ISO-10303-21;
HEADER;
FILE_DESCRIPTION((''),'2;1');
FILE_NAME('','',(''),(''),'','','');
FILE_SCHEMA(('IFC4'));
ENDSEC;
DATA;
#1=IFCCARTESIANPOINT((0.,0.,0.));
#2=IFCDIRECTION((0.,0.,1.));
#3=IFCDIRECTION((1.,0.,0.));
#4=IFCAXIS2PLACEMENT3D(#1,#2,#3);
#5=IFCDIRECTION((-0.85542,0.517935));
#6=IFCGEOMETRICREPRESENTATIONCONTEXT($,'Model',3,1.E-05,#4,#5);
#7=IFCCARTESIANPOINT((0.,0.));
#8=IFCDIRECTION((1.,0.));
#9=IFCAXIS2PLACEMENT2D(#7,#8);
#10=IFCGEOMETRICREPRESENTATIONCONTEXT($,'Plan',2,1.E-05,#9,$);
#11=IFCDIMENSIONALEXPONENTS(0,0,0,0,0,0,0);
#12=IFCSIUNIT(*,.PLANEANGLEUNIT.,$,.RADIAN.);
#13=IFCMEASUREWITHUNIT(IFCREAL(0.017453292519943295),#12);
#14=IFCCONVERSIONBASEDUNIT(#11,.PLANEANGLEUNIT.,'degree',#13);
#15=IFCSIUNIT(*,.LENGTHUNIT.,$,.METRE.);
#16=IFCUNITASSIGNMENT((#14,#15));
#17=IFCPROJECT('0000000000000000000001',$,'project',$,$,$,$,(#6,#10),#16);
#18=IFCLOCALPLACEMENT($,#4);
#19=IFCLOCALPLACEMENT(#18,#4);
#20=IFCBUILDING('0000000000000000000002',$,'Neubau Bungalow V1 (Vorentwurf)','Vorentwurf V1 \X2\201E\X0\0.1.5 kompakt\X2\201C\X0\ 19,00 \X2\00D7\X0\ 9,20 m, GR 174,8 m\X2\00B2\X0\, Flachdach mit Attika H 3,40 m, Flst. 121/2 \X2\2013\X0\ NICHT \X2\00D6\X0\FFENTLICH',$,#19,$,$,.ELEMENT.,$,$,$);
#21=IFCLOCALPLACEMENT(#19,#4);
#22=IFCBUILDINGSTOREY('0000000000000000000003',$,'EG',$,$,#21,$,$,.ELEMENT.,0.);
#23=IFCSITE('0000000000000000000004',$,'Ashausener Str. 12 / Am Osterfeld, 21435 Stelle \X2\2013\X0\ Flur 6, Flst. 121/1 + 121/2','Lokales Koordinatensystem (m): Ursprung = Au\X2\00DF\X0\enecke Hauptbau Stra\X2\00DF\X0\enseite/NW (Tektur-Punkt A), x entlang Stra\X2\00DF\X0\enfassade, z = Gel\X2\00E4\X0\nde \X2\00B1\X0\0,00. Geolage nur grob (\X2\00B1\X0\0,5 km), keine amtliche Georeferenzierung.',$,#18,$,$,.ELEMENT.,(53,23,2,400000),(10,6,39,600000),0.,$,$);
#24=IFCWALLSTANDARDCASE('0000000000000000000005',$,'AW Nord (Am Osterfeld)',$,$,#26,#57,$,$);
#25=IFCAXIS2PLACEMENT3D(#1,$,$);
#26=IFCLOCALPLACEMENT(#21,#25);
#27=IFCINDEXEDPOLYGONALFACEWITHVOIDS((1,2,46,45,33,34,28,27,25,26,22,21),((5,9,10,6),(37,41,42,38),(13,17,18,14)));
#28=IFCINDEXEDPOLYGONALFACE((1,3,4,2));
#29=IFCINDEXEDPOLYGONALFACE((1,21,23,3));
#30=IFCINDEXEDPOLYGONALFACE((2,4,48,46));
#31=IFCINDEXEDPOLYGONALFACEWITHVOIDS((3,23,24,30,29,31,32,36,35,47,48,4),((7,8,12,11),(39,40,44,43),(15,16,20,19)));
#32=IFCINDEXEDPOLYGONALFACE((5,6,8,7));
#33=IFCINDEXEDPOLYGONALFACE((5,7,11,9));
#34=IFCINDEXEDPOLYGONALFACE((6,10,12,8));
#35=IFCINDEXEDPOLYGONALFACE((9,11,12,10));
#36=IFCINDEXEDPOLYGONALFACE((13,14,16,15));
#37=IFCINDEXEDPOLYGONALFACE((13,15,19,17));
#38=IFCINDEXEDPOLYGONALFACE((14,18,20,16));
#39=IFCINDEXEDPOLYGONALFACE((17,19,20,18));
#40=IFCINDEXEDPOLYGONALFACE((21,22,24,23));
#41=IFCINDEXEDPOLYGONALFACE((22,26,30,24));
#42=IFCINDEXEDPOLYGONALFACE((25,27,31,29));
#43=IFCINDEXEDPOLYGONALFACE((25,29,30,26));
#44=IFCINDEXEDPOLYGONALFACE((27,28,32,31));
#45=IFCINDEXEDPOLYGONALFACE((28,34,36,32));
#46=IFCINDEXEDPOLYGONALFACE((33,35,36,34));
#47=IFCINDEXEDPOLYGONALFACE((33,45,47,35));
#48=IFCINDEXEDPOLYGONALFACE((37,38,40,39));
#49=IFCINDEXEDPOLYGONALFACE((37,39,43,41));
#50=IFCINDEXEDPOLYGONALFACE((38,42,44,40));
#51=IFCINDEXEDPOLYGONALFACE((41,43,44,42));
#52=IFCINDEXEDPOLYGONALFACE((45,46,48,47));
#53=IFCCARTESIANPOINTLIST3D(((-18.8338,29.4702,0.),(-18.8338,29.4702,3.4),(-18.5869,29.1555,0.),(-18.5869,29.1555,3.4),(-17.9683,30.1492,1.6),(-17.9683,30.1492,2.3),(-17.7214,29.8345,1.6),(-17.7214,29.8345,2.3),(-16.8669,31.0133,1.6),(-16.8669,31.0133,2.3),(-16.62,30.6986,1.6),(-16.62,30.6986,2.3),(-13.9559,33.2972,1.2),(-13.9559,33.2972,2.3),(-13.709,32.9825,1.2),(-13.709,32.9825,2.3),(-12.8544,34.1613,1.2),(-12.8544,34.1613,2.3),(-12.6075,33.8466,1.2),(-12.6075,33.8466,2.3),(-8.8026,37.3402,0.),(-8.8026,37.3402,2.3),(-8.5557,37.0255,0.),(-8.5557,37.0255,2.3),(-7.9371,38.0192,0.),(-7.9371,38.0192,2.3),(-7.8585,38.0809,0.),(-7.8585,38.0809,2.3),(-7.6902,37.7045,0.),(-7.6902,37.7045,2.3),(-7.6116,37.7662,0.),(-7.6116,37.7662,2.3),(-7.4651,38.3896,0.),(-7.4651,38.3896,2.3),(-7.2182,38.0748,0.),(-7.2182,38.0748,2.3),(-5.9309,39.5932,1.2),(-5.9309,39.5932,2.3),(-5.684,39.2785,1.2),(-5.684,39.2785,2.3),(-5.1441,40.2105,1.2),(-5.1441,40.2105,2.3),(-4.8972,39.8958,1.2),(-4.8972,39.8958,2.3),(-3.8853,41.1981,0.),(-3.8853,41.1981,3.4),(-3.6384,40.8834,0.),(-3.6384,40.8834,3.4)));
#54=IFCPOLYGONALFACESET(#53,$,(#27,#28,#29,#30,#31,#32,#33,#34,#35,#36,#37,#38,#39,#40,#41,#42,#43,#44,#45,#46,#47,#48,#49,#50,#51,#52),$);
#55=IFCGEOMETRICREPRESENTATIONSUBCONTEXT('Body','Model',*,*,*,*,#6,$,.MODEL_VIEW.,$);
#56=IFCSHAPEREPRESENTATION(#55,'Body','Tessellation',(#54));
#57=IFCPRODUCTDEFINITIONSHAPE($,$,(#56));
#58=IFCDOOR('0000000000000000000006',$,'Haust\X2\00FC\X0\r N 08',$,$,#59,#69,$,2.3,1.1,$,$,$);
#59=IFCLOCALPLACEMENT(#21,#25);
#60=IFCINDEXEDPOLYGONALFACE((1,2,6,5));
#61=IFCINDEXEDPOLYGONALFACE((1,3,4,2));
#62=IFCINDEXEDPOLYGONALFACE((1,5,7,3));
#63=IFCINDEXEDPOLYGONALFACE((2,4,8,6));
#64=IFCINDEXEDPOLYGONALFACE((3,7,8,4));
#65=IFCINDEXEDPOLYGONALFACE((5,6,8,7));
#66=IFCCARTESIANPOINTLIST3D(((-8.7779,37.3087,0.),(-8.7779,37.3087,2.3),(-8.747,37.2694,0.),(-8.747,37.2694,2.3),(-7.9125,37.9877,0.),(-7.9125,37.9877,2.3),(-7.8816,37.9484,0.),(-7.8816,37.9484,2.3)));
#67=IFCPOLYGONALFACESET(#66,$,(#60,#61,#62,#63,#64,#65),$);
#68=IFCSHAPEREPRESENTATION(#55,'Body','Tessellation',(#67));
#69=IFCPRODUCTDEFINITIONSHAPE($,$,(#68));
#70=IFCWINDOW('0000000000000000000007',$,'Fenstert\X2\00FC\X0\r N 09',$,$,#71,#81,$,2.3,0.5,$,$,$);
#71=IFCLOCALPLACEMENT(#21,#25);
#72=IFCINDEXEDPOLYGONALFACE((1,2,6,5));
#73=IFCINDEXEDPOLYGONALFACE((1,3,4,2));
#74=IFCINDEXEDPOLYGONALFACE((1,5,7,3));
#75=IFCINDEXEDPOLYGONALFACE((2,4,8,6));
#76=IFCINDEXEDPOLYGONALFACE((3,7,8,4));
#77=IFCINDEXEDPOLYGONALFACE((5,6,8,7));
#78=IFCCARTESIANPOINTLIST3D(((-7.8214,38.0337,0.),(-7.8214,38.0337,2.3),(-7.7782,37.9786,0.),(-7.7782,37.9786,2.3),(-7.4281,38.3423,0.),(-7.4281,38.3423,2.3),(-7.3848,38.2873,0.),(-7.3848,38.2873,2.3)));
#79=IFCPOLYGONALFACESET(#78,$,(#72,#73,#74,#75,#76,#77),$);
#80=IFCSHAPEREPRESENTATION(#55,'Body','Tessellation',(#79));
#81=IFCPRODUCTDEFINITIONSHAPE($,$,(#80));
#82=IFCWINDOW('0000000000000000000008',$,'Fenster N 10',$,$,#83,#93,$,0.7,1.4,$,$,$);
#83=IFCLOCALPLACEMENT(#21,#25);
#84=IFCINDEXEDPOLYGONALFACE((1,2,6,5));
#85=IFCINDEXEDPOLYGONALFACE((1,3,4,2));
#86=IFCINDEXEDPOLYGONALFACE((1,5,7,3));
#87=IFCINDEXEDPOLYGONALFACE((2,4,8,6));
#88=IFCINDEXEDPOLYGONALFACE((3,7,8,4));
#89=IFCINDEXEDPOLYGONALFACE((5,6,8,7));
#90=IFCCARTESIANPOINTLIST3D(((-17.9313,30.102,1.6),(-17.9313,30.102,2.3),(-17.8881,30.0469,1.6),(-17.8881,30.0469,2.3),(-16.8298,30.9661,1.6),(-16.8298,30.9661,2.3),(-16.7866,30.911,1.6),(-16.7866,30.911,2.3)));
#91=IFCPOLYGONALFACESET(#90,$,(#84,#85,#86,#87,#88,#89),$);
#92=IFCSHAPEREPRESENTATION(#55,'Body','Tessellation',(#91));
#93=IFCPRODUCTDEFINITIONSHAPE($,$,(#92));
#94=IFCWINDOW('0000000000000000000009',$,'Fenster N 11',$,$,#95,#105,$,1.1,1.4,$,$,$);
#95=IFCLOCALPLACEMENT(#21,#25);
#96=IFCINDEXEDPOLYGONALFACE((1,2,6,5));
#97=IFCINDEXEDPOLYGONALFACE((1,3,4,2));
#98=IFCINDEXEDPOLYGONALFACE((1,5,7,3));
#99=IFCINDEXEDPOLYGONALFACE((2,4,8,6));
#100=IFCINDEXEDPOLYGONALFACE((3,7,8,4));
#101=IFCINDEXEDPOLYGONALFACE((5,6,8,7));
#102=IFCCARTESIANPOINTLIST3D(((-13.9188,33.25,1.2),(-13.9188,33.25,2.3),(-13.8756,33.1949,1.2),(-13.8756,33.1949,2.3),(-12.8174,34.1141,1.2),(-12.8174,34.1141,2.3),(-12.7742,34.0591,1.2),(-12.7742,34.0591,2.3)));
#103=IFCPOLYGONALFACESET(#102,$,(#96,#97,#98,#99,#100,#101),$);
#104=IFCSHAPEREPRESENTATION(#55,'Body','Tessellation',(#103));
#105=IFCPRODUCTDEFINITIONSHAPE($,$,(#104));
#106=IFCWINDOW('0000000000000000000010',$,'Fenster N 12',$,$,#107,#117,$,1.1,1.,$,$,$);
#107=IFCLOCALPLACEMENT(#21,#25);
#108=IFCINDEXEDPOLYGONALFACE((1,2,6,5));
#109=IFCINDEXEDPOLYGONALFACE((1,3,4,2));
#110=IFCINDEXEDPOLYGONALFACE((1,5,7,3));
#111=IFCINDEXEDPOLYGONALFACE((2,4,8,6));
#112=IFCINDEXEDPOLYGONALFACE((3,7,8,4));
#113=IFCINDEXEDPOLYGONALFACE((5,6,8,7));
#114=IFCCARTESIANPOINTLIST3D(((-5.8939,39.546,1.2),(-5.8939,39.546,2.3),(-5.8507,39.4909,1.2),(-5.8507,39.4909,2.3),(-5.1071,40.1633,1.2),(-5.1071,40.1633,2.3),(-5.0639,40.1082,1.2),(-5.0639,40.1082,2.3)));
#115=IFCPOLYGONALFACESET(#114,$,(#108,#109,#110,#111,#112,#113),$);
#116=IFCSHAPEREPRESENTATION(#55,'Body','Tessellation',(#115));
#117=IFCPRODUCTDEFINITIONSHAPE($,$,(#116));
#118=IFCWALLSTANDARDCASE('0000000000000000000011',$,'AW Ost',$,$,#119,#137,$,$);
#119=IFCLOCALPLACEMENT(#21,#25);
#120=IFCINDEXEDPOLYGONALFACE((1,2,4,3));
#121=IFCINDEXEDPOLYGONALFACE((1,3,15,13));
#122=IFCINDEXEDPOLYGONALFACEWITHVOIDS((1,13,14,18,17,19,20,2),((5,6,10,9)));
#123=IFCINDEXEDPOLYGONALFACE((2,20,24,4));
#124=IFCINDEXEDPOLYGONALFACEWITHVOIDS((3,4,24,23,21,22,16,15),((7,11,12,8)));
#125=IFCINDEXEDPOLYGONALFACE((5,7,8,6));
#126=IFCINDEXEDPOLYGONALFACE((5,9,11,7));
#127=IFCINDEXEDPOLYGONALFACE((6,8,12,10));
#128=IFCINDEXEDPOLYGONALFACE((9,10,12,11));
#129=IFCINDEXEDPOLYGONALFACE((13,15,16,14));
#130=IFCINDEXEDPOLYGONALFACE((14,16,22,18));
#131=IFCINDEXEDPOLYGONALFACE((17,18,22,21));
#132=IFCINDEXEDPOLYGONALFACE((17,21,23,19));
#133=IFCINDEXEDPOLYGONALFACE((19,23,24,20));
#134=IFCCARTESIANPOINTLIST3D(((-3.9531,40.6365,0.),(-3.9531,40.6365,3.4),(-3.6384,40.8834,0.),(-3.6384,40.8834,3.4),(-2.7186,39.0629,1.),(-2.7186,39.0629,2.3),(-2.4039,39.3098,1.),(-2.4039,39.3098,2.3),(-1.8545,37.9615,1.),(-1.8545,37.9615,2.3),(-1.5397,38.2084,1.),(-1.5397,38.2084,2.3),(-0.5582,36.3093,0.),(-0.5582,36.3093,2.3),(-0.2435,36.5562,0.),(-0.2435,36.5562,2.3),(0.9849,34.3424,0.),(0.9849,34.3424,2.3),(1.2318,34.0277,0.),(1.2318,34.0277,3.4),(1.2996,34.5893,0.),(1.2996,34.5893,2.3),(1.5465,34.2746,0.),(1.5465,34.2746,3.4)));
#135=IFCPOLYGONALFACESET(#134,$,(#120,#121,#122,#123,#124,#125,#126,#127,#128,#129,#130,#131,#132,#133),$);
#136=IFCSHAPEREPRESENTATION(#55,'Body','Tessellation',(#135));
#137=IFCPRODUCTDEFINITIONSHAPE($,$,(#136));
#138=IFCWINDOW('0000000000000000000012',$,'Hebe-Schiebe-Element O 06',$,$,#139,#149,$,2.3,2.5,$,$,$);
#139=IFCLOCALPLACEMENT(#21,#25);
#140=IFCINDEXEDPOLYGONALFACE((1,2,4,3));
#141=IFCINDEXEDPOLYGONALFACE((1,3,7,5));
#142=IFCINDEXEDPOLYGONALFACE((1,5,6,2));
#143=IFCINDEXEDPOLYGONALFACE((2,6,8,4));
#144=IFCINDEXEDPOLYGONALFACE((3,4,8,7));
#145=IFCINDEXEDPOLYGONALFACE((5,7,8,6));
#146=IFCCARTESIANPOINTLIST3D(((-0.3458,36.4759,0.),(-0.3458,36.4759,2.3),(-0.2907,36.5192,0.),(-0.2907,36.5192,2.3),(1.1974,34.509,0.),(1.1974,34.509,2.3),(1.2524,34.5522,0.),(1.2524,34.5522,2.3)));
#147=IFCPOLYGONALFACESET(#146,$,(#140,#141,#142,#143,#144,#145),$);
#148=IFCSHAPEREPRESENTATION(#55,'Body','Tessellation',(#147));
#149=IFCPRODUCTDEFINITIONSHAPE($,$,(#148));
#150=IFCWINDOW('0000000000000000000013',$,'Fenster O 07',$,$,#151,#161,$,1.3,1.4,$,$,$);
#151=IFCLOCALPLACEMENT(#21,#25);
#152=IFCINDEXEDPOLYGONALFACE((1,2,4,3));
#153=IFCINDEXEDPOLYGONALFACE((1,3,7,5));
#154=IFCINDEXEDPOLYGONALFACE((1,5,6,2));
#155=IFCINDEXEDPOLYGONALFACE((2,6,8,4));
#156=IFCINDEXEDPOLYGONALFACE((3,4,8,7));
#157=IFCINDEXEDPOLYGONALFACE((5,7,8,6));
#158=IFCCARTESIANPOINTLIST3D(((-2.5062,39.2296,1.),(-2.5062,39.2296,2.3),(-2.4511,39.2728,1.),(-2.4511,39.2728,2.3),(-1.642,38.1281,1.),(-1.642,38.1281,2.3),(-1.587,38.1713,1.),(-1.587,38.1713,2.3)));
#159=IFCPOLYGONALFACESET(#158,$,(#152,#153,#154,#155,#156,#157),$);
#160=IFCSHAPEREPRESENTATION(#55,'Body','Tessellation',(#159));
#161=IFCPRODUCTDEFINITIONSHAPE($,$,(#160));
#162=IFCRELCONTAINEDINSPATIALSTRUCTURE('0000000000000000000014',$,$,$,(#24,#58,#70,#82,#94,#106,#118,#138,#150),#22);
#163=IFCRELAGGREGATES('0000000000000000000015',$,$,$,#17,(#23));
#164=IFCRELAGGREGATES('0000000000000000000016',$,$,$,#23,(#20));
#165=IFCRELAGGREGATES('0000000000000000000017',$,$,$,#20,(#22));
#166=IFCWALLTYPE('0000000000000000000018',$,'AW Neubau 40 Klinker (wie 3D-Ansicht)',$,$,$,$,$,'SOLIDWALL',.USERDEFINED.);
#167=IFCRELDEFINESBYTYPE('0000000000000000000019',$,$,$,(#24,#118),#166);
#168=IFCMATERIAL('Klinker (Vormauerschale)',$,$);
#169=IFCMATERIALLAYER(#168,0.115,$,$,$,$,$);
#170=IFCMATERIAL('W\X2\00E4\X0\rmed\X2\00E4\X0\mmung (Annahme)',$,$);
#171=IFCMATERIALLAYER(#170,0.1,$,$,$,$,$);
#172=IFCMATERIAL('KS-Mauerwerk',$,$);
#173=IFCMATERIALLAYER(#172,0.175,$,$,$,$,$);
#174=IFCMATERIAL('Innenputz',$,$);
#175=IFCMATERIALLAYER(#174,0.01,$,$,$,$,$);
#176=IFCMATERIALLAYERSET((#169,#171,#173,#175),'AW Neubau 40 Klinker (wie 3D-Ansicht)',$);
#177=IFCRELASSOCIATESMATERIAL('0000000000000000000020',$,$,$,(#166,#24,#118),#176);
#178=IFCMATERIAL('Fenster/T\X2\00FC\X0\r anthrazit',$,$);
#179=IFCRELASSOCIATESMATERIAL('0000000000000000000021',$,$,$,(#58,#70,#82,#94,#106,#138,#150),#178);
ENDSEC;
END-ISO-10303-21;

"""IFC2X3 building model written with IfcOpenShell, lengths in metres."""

from ifc_helpers import new_model, entity, si_unit, converted_unit, direction, frame, origin_with_axes, origin_2d_with_axis, place, context, subcontext, project, spatial, polyline, outline, extrude, material, layer, layer_set, layer_usage, type_object, element, fill, save


model = new_model("IFC2X3")

# Units and contexts
model_context = context("Model", 3, precision=1e-05, world=origin_with_axes(), true_north=direction((-0.85542, 0.517935)))
plan_context = context("Plan", 2, precision=1e-05, world=origin_2d_with_axis())
body_context = subcontext(model_context, "Body", "Model", "MODEL_VIEW")
ifc_project = project(units=[converted_unit("PLANEANGLEUNIT", "degree", entity("IfcReal", 0.017453292519943295), si_unit("PLANEANGLEUNIT", "RADIAN"), dimensions=[0, 0, 0, 0, 0, 0, 0]), si_unit("LENGTHUNIT", "METRE")], contexts=[model_context, plan_context])

# Site, building, storey
site_placement = place(None, origin_with_axes())
site = spatial("IfcSite", under=ifc_project, at=site_placement, Name="Ashausener Str. 12 / Am Osterfeld, 21435 Stelle – Flur 6, Flst. 121/1 + 121/2", Description="Lokales Koordinatensystem (m): Ursprung = Außenecke Hauptbau Straßenseite/NW (Tektur-Punkt A), x entlang Straßenfassade, z = Gelände ±0,00. Geolage nur grob (±0,5 km), keine amtliche Georeferenzierung.", CompositionType="ELEMENT", RefLatitude=(53, 23, 2, 400000), RefLongitude=(10, 6, 39, 600000), RefElevation=0.0)
building_placement = place(site_placement, origin_with_axes())
building = spatial("IfcBuilding", under=site, at=building_placement, Name="Neubau Bungalow V1 (Vorentwurf)", Description="Vorentwurf V1 „0.1.5 kompakt“ 19,00 × 9,20 m, GR 174,8 m², Flachdach mit Attika H 3,40 m, Flst. 121/2 – NICHT ÖFFENTLICH", CompositionType="ELEMENT")
storey_placement = place(building_placement, origin_with_axes())
storey = spatial("IfcBuildingStorey", under=building, at=storey_placement, Name="EG", CompositionType="ELEMENT", Elevation=0.0)

# Wall, openings, door, windows
ifc_material_1 = material(Name="Klinker (Vormauerschale)")
ifc_layer_1 = layer(ifc_material_1, 0.115)
ifc_material_2 = material(Name="Wärmedämmung (Annahme)")
ifc_layer_2 = layer(ifc_material_2, 0.1)
ifc_material_3 = material(Name="KS-Mauerwerk")
ifc_layer_3 = layer(ifc_material_3, 0.175)
ifc_material_4 = material(Name="Innenputz")
ifc_layer_4 = layer(ifc_material_4, 0.01)
ifc_layer_set_1 = layer_set([ifc_layer_1, ifc_layer_2, ifc_layer_3, ifc_layer_4], Name="AW Neubau 40 Klinker (wie 3D-Ansicht)")
ifc_layer_usage_1 = layer_usage(ifc_layer_set_1, "AXIS2", "POSITIVE", 0.0)
wall_type_1 = type_object("IfcWallType", Name="AW Neubau 40 Klinker (wie 3D-Ansicht)", ElementType="SOLIDWALL", PredefinedType="USERDEFINED", material=ifc_layer_set_1)
wall_1_placement = place(storey_placement, frame((-3.8853, 41.1981, 0.0), z_axis=(0.0, 0.0, 1.0), x_axis=(-0.786761, -0.617258, 0.0)))
wall_1 = element("IfcWallStandardCase", 1, at=wall_1_placement, inside=storey, type_object=wall_type_1, material=ifc_layer_usage_1, Name="AW Nord (Am Osterfeld)", context=body_context, shape_type="SweptSolid", body=[
    extrude(outline(polyline([(0.0, 0.0), (0.0, 0.4), (19.0, 0.4), (19.0, 0.0), (0.0, 0.0)])), origin_with_axes(), (0.0, 0.0, 1.0), 3.4),
])
opening_1_placement = place(wall_1_placement, frame((5.15, -0.1, 0.0), z_axis=(0.0, 0.0, 1.0), x_axis=(1.0, 0.0, 0.0)))
opening_1 = element("IfcOpeningElement", 2, at=opening_1_placement, cuts=wall_1, context=body_context, shape_type="SweptSolid", body=[
    extrude(outline(polyline([(0.0, 0.0), (0.0, 0.6), (1.1, 0.6), (1.1, 0.0), (0.0, 0.0)])), origin_with_axes(), (0.0, 0.0, 1.0), 2.3),
])
opening_2_placement = place(wall_1_placement, frame((4.55, -0.1, 0.0), z_axis=(0.0, 0.0, 1.0), x_axis=(1.0, 0.0, 0.0)))
opening_2 = element("IfcOpeningElement", 3, at=opening_2_placement, cuts=wall_1, context=body_context, shape_type="SweptSolid", body=[
    extrude(outline(polyline([(0.0, 0.0), (0.0, 0.6), (0.5, 0.6), (0.5, 0.0), (0.0, 0.0)])), origin_with_axes(), (0.0, 0.0, 1.0), 2.3),
])
opening_3_placement = place(wall_1_placement, frame((16.5, -0.1, 1.6), z_axis=(0.0, 0.0, 1.0), x_axis=(1.0, 0.0, 0.0)))
opening_3 = element("IfcOpeningElement", 4, at=opening_3_placement, cuts=wall_1, context=body_context, shape_type="SweptSolid", body=[
    extrude(outline(polyline([(0.0, 0.0), (0.0, 0.6), (1.4, 0.6), (1.4, 0.0), (0.0, 0.0)])), origin_with_axes(), (0.0, 0.0, 1.0), 0.7),
])
opening_4_placement = place(wall_1_placement, frame((11.4, -0.1, 1.2), z_axis=(0.0, 0.0, 1.0), x_axis=(1.0, 0.0, 0.0)))
opening_4 = element("IfcOpeningElement", 5, at=opening_4_placement, cuts=wall_1, context=body_context, shape_type="SweptSolid", body=[
    extrude(outline(polyline([(0.0, 0.0), (0.0, 0.6), (1.4, 0.6), (1.4, 0.0), (0.0, 0.0)])), origin_with_axes(), (0.0, 0.0, 1.0), 1.1),
])
opening_5_placement = place(wall_1_placement, frame((1.6, -0.1, 1.2), z_axis=(0.0, 0.0, 1.0), x_axis=(1.0, 0.0, 0.0)))
opening_5 = element("IfcOpeningElement", 6, at=opening_5_placement, cuts=wall_1, context=body_context, shape_type="SweptSolid", body=[
    extrude(outline(polyline([(0.0, 0.0), (0.0, 0.6), (1.0, 0.6), (1.0, 0.0), (0.0, 0.0)])), origin_with_axes(), (0.0, 0.0, 1.0), 1.1),
])
ifc_material_5 = material(Name="Fenster/Tür anthrazit")
door_placement = place(storey_placement, frame((-7.9125, 37.9877, 0.0), z_axis=(0.0, 0.0, 1.0), x_axis=(-0.786761, -0.617258, 0.0)))
door = element("IfcDoor", 7, at=door_placement, inside=storey, material=ifc_material_5, Name="Haustür N 08", OverallHeight=2.3, OverallWidth=1.1, context=body_context, shape_type="SweptSolid", body=[
    extrude(outline(polyline([(0.0, 0.0), (0.0, 0.05), (1.1, 0.05), (1.1, 0.0), (0.0, 0.0)])), origin_with_axes(), (0.0, 0.0, 1.0), 2.3),
])
fill(opening_1, door)
window_1_placement = place(storey_placement, frame((-7.4281, 38.3423, 0.0), z_axis=(0.0, 0.0, 1.0), x_axis=(-0.786761, -0.617258, 0.0)))
window_1 = element("IfcWindow", 8, at=window_1_placement, inside=storey, material=ifc_material_5, Name="Fenstertür N 09", OverallHeight=2.3, OverallWidth=0.5, context=body_context, shape_type="SweptSolid", body=[
    extrude(outline(polyline([(0.0, 0.0), (0.0, 0.07), (0.5, 0.07), (0.5, 0.0), (0.0, 0.0)])), origin_with_axes(), (0.0, 0.0, 1.0), 2.3),
])
fill(opening_2, window_1)
window_2_placement = place(storey_placement, frame((-16.8298, 30.9661, 1.6), z_axis=(0.0, 0.0, 1.0), x_axis=(-0.786761, -0.617258, 0.0)))
window_2 = element("IfcWindow", 9, at=window_2_placement, inside=storey, material=ifc_material_5, Name="Fenster N 10", OverallHeight=0.7, OverallWidth=1.4, context=body_context, shape_type="SweptSolid", body=[
    extrude(outline(polyline([(0.0, 0.0), (0.0, 0.07), (1.4, 0.07), (1.4, 0.0), (0.0, 0.0)])), origin_with_axes(), (0.0, 0.0, 1.0), 0.7),
])
fill(opening_3, window_2)
window_3_placement = place(storey_placement, frame((-12.8174, 34.1141, 1.2), z_axis=(0.0, 0.0, 1.0), x_axis=(-0.786761, -0.617258, 0.0)))
window_3 = element("IfcWindow", 10, at=window_3_placement, inside=storey, material=ifc_material_5, Name="Fenster N 11", OverallHeight=1.1, OverallWidth=1.4, context=body_context, shape_type="SweptSolid", body=[
    extrude(outline(polyline([(0.0, 0.0), (0.0, 0.07), (1.4, 0.07), (1.4, 0.0), (0.0, 0.0)])), origin_with_axes(), (0.0, 0.0, 1.0), 1.1),
])
fill(opening_4, window_3)
window_4_placement = place(storey_placement, frame((-5.1071, 40.1633, 1.2), z_axis=(0.0, 0.0, 1.0), x_axis=(-0.786761, -0.617258, 0.0)))
window_4 = element("IfcWindow", 11, at=window_4_placement, inside=storey, material=ifc_material_5, Name="Fenster N 12", OverallHeight=1.1, OverallWidth=1.0, context=body_context, shape_type="SweptSolid", body=[
    extrude(outline(polyline([(0.0, 0.0), (0.0, 0.07), (1.0, 0.07), (1.0, 0.0), (0.0, 0.0)])), origin_with_axes(), (0.0, 0.0, 1.0), 1.1),
])
fill(opening_5, window_4)

# Wall, openings, windows
ifc_layer_usage_2 = layer_usage(ifc_layer_set_1, "AXIS2", "POSITIVE", 0.0)
wall_2_placement = place(storey_placement, frame((1.5465, 34.2746, 0.0), z_axis=(0.0, 0.0, 1.0), x_axis=(-0.617258, 0.786761, 0.0)))
wall_2 = element("IfcWallStandardCase", 12, at=wall_2_placement, inside=storey, type_object=wall_type_1, material=ifc_layer_usage_2, Name="AW Ost", context=body_context, shape_type="SweptSolid", body=[
    extrude(outline(polyline([(0.0, 0.0), (0.0, 0.4), (8.4, 0.4), (8.4, 0.0), (0.0, 0.0)])), origin_with_axes(), (0.0, 0.0, 1.0), 3.4),
])
opening_6_placement = place(wall_2_placement, frame((0.4, -0.1, 0.0), z_axis=(0.0, 0.0, 1.0), x_axis=(1.0, 0.0, 0.0)))
opening_6 = element("IfcOpeningElement", 13, at=opening_6_placement, cuts=wall_2, context=body_context, shape_type="SweptSolid", body=[
    extrude(outline(polyline([(0.0, 0.0), (0.0, 0.6), (2.5, 0.6), (2.5, 0.0), (0.0, 0.0)])), origin_with_axes(), (0.0, 0.0, 1.0), 2.3),
])
opening_7_placement = place(wall_2_placement, frame((5.0, -0.1, 1.0), z_axis=(0.0, 0.0, 1.0), x_axis=(1.0, 0.0, 0.0)))
opening_7 = element("IfcOpeningElement", 14, at=opening_7_placement, cuts=wall_2, context=body_context, shape_type="SweptSolid", body=[
    extrude(outline(polyline([(0.0, 0.0), (0.0, 0.6), (1.4, 0.6), (1.4, 0.0), (0.0, 0.0)])), origin_with_axes(), (0.0, 0.0, 1.0), 1.3),
])
window_5_placement = place(storey_placement, frame((1.2524, 34.5522, 0.0), z_axis=(0.0, 0.0, 1.0), x_axis=(-0.617258, 0.786761, 0.0)))
window_5 = element("IfcWindow", 15, at=window_5_placement, inside=storey, material=ifc_material_5, Name="Hebe-Schiebe-Element O 06", OverallHeight=2.3, OverallWidth=2.5, context=body_context, shape_type="SweptSolid", body=[
    extrude(outline(polyline([(0.0, 0.0), (0.0, 0.07), (2.5, 0.07), (2.5, 0.0), (0.0, 0.0)])), origin_with_axes(), (0.0, 0.0, 1.0), 2.3),
])
fill(opening_6, window_5)
window_6_placement = place(storey_placement, frame((-1.587, 38.1713, 1.0), z_axis=(0.0, 0.0, 1.0), x_axis=(-0.617258, 0.786761, 0.0)))
window_6 = element("IfcWindow", 16, at=window_6_placement, inside=storey, material=ifc_material_5, Name="Fenster O 07", OverallHeight=1.3, OverallWidth=1.4, context=body_context, shape_type="SweptSolid", body=[
    extrude(outline(polyline([(0.0, 0.0), (0.0, 0.07), (1.4, 0.07), (1.4, 0.0), (0.0, 0.0)])), origin_with_axes(), (0.0, 0.0, 1.0), 1.3),
])
fill(opening_7, window_6)

save(model, "model.ifc")
